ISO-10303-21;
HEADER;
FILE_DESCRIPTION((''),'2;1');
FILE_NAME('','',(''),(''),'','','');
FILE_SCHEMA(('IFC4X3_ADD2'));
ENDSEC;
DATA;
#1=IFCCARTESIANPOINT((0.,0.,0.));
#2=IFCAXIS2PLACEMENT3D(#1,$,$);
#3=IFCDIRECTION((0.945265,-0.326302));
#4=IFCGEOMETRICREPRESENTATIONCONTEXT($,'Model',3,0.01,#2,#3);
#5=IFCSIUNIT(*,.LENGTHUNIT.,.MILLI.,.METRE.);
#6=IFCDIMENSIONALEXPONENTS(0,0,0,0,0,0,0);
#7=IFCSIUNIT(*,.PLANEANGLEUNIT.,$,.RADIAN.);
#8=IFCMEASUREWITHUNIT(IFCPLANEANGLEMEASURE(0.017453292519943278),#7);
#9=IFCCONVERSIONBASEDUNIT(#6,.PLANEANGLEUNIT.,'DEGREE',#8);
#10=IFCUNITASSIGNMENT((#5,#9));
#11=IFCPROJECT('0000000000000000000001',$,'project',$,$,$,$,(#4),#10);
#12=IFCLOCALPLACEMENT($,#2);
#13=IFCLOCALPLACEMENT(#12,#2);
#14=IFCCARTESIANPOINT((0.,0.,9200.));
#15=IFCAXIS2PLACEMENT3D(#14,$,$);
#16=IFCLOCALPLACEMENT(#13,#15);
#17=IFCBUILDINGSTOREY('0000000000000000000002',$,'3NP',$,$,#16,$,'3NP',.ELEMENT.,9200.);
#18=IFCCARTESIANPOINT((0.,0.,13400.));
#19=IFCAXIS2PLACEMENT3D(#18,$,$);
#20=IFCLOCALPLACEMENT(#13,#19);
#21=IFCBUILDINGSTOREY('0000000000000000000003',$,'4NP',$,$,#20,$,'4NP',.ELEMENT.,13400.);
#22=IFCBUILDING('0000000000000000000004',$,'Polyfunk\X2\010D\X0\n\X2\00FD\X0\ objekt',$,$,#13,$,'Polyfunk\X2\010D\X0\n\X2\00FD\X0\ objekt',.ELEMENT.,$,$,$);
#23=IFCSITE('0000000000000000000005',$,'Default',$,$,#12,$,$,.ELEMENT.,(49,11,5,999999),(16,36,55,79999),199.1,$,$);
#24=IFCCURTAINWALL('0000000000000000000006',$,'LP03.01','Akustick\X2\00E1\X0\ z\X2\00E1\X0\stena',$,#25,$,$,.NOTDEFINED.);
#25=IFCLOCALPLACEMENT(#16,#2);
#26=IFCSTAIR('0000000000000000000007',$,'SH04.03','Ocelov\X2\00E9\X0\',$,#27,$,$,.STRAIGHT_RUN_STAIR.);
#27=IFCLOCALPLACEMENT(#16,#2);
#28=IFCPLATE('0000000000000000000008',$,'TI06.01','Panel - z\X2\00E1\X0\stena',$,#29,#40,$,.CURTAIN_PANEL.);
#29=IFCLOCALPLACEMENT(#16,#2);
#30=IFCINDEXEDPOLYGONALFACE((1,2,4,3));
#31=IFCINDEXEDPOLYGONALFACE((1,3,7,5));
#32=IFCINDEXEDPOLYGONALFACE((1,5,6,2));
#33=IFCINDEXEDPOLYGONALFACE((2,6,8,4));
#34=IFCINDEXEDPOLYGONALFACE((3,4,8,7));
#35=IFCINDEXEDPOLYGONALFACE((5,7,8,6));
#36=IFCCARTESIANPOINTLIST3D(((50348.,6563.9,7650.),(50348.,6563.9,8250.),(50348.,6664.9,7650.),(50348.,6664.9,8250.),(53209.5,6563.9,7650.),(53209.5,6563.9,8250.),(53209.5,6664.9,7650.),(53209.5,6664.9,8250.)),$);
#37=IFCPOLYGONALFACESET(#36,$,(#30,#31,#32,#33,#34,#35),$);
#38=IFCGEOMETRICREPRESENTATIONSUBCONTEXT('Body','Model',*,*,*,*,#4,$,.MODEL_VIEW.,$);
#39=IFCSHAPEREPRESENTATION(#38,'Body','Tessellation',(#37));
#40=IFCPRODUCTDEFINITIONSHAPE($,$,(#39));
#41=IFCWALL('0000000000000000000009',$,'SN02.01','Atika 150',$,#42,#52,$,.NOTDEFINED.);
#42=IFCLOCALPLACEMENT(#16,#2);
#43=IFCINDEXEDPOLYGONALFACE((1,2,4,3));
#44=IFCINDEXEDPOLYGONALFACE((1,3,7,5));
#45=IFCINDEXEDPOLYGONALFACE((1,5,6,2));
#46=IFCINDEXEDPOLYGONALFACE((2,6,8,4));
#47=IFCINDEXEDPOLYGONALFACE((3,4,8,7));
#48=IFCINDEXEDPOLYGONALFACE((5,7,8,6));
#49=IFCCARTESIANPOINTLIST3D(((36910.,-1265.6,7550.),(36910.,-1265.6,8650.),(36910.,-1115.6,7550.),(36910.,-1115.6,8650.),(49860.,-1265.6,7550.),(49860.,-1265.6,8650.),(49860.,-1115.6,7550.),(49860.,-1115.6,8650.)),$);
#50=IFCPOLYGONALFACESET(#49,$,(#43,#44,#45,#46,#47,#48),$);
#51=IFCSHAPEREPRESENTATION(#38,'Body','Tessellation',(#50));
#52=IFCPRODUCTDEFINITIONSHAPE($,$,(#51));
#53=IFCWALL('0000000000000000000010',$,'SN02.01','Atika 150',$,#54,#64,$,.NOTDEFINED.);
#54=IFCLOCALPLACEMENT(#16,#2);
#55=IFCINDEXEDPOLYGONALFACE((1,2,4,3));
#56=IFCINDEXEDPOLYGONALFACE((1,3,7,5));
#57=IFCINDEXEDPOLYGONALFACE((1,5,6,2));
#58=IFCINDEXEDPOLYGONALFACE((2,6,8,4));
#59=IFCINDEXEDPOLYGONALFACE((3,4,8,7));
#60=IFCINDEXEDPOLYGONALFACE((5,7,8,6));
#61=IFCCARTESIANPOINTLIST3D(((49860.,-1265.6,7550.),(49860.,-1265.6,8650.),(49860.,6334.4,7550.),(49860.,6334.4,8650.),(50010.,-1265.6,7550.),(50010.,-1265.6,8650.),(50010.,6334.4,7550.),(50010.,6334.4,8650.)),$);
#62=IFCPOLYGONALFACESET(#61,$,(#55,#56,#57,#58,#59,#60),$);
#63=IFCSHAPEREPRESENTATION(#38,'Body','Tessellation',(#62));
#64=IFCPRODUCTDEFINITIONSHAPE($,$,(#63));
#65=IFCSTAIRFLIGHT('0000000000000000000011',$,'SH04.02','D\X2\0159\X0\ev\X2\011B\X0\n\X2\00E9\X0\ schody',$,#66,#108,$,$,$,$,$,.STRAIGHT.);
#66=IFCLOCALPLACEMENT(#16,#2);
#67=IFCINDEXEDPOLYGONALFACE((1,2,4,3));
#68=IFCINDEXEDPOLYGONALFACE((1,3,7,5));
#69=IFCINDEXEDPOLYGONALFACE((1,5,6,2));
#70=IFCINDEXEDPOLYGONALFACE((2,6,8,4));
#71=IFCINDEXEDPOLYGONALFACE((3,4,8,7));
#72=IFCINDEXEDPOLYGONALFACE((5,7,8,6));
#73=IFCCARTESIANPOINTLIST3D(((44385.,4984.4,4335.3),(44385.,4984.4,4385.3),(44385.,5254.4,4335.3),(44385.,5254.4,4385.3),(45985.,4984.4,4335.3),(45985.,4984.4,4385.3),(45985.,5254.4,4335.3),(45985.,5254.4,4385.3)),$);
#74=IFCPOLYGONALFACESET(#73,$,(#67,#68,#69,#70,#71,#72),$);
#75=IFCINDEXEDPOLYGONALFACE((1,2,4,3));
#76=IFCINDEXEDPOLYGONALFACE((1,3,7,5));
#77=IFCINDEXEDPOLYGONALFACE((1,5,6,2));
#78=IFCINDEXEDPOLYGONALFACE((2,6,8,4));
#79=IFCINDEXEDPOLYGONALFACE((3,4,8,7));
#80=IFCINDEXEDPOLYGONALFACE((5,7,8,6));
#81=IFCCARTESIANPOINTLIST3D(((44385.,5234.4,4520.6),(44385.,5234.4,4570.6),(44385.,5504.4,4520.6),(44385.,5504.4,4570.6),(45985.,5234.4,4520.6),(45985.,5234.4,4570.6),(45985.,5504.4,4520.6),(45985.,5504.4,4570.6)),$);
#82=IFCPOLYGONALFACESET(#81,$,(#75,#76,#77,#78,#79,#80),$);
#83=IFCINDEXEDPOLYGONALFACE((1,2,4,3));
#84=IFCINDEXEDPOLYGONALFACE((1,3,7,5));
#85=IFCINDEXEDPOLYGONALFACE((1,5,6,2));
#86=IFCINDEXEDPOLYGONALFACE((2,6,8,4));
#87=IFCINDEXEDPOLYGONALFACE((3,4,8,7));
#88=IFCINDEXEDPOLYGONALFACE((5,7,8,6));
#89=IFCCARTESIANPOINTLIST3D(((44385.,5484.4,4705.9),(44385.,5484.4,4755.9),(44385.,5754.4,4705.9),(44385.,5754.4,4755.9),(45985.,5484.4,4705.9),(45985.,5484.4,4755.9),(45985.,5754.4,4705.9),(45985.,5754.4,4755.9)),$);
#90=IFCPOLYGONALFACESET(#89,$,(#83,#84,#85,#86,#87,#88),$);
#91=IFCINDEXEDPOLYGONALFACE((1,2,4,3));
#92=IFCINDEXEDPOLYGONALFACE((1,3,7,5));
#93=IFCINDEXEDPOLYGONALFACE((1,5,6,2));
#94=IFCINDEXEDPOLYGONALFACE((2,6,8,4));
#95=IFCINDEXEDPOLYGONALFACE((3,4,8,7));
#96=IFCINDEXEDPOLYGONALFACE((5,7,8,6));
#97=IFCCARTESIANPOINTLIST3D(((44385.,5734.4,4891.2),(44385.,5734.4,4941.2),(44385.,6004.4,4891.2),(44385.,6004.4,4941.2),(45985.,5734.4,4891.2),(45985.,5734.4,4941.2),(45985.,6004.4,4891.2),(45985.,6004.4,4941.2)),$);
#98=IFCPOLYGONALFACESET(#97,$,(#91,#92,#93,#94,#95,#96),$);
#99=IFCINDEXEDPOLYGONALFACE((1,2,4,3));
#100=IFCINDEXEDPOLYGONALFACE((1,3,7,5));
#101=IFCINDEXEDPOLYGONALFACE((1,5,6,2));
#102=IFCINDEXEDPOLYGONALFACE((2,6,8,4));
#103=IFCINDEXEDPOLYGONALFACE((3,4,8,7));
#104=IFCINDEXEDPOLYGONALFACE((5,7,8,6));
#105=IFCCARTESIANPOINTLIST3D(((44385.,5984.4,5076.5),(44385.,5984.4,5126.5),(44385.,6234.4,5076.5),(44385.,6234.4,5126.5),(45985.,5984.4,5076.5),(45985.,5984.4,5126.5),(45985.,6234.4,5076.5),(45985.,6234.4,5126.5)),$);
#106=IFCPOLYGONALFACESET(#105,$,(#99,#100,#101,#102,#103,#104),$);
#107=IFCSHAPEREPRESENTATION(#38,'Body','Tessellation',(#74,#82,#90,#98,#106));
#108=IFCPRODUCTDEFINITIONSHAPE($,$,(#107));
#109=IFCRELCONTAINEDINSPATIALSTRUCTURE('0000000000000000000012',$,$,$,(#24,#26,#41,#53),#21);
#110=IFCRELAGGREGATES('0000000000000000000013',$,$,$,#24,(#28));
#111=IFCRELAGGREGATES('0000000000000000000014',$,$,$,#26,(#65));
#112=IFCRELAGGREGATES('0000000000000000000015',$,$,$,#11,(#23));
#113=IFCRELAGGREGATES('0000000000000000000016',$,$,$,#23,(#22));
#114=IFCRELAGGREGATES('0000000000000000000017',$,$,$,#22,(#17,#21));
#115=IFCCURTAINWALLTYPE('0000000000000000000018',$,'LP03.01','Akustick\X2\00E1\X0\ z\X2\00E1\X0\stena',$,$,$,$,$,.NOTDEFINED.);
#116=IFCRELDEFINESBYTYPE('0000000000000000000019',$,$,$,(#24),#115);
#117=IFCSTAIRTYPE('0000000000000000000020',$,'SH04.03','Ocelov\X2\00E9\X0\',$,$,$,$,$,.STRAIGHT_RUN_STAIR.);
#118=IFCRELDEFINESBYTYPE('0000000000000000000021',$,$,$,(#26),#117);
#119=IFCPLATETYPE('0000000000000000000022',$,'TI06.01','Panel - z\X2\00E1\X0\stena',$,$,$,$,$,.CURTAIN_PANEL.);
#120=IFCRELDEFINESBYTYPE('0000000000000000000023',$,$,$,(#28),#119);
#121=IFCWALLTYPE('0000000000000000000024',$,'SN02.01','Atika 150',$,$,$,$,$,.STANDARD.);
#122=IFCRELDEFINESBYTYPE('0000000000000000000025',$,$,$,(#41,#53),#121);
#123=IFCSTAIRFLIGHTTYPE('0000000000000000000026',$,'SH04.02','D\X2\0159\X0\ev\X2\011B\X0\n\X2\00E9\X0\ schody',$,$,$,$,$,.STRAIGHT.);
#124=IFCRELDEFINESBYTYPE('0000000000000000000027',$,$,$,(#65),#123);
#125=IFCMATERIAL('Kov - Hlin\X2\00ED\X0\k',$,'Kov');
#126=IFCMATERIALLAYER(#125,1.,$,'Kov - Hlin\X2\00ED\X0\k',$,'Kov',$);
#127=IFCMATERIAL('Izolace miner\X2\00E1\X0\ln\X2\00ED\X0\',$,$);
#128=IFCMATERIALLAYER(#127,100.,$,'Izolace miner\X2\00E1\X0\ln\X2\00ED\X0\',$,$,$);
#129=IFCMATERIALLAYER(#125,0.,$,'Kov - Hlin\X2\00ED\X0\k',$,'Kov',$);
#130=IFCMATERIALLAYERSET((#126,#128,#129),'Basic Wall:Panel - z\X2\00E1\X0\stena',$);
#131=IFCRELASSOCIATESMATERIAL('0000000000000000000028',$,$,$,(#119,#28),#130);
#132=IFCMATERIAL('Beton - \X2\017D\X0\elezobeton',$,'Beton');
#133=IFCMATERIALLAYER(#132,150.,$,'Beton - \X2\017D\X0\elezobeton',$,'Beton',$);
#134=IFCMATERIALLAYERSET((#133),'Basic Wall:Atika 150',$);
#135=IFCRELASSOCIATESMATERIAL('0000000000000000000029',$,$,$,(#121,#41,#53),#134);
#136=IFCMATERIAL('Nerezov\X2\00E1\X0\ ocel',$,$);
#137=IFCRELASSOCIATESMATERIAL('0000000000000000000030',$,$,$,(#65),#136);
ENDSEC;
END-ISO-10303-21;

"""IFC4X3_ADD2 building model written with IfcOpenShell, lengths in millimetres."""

from ifc_helpers import new_model, entity, si_unit, converted_unit, direction, frame, frame_2d, origin, origin_2d_with_axis, place, context, subcontext, project, spatial, rectangle, extrude, material, layer, layer_set, layer_usage, type_object, element, aggregate, save


model = new_model("IFC4X3_ADD2")

# Units and contexts
model_context = context("Model", 3, precision=0.01, world=origin(), true_north=direction((0.945265, -0.326302)))
body_context = subcontext(model_context, "Body", "Model", "MODEL_VIEW")
ifc_project = project(units=[si_unit("LENGTHUNIT", "METRE", prefix="MILLI"), converted_unit("PLANEANGLEUNIT", "DEGREE", entity("IfcPlaneAngleMeasure", 0.017453292519943278), si_unit("PLANEANGLEUNIT", "RADIAN"), dimensions=[0, 0, 0, 0, 0, 0, 0])], contexts=[model_context])

# Site, building, storey
site_placement = place(None, origin())
site = spatial("IfcSite", under=ifc_project, at=site_placement, Name="Default", CompositionType="ELEMENT", RefLatitude=(49, 11, 5, 999999), RefLongitude=(16, 36, 55, 79999), RefElevation=199.1)
building_placement = place(site_placement, origin())
building = spatial("IfcBuilding", under=site, at=building_placement, Name="Polyfunkčný objekt", LongName="Polyfunkčný objekt", CompositionType="ELEMENT")
storey_1_placement = place(building_placement, frame((0.0, 0.0, 9200.0)))
storey_1 = spatial("IfcBuildingStorey", under=building, at=storey_1_placement, Name="3NP", LongName="3NP", CompositionType="ELEMENT", Elevation=9200.0)

# Shared definitions
storey_2_placement = place(building_placement, frame((0.0, 0.0, 13400.0)))
storey_2 = spatial("IfcBuildingStorey", under=building, at=storey_2_placement, Name="4NP", LongName="4NP", CompositionType="ELEMENT", Elevation=13400.0)

# Curtain wall
curtain_wall_type_1 = type_object("IfcCurtainWallType", Name="LP03.01", Description="Akustická zástena", PredefinedType="NOTDEFINED")
curtain_wall_1_placement = place(storey_2_placement, frame((0.0, 0.0, -13400.0)))
curtain_wall_1 = element("IfcCurtainWall", 1, at=curtain_wall_1_placement, inside=storey_2, type_object=curtain_wall_type_1, Name="LP03.01", Description="Akustická zástena", PredefinedType="NOTDEFINED")
ifc_material_1 = material(Name="Nerezová ocel")

# Stair
stair_type = type_object("IfcStairType", Name="SH04.03", Description="Ocelové", PredefinedType="STRAIGHT_RUN_STAIR")
stair_placement = place(storey_2_placement, origin())
stair = element("IfcStair", 2, at=stair_placement, inside=storey_2, type_object=stair_type, Name="SH04.03", Description="Ocelové", PredefinedType="STRAIGHT_RUN_STAIR")

# Plate
ifc_material_2 = material(Name="Kov - Hliník", Category="Kov")
ifc_layer_1 = layer(ifc_material_2, 1.0, Name="Kov - Hliník", Category="Kov")
ifc_material_3 = material(Name="Izolace minerální")
ifc_layer_2 = layer(ifc_material_3, 100.0, Name="Izolace minerální")
ifc_layer_3 = layer(ifc_material_2, 0.0, Name="Kov - Hliník", Category="Kov")
ifc_layer_set_1 = layer_set([ifc_layer_1, ifc_layer_2, ifc_layer_3], Name="Basic Wall:Panel - zástena")
plate_type = type_object("IfcPlateType", Name="TI06.01", Description="Panel - zástena", PredefinedType="CURTAIN_PANEL", material=ifc_layer_set_1)
ifc_layer_usage_1 = layer_usage(ifc_layer_set_1, "AXIS2", "POSITIVE", -50.5)
plate_1_placement = place(storey_2_placement, frame((50348.0, 6614.4, 3450.0)))
plate_1 = element("IfcPlate", 3, at=plate_1_placement, type_object=plate_type, material=ifc_layer_usage_1, Name="TI06.01", Description="Panel - zástena", PredefinedType="CURTAIN_PANEL", context=body_context, shape_type="SweptSolid", body=[
    extrude(rectangle(XDim=101.0, YDim=2861.5, at=frame_2d((0.0, 0.0), x_axis=(1.0, 0.0))), frame((1430.7, 0.0, 0.0), z_axis=(0.0, 0.0, 1.0), x_axis=(0.0, 1.0, 0.0)), (0.0, 0.0, 1.0), 600.0),
])
aggregate(curtain_wall_1, [plate_1])

# Walls
ifc_material_4 = material(Name="Beton - Železobeton", Category="Beton")
ifc_layer_4 = layer(ifc_material_4, 150.0, Name="Beton - Železobeton", Category="Beton")
ifc_layer_set_2 = layer_set([ifc_layer_4], Name="Basic Wall:Atika 150")
wall_type = type_object("IfcWallType", Name="SN02.01", Description="Atika 150", PredefinedType="STANDARD", material=ifc_layer_set_2)
wall_1_placement = place(storey_2_placement, frame((49860.0, -1190.6, 3350.0), z_axis=(0.0, 0.0, 1.0), x_axis=(-1.0, 0.0, 0.0)))
element("IfcWall", 4, at=wall_1_placement, inside=storey_2, type_object=wall_type, material=ifc_layer_set_2, Name="SN02.01", Description="Atika 150", PredefinedType="NOTDEFINED", context=body_context, shape_type="SweptSolid", body=[
    extrude(rectangle(XDim=12950.0, YDim=150.0, at=frame_2d((6475.0, 0.0), x_axis=(-1.0, 0.0))), origin(), (0.0, 0.0, 1.0), 1100.0),
])
wall_2_placement = place(storey_2_placement, frame((49935.0, 6334.4, 3350.0), z_axis=(0.0, 0.0, 1.0), x_axis=(0.0, -1.0, 0.0)))
element("IfcWall", 5, at=wall_2_placement, inside=storey_2, type_object=wall_type, material=ifc_layer_set_2, Name="SN02.01", Description="Atika 150", PredefinedType="NOTDEFINED", context=body_context, shape_type="SweptSolid", body=[
    extrude(rectangle(XDim=7600.0, YDim=150.0, at=frame_2d((3800.0, 0.0), x_axis=(-1.0, 0.0))), origin(), (0.0, 0.0, 1.0), 1100.0),
])

# Stair flight
stair_flight_type = type_object("IfcStairFlightType", Name="SH04.02", Description="Dřevěné schody", PredefinedType="STRAIGHT")
stair_flight_placement = place(stair_placement, frame((44385.0, 4984.4, 0.0)))
stair_flight = element("IfcStairFlight", 6, at=stair_flight_placement, type_object=stair_flight_type, material=ifc_material_1, Name="SH04.02", Description="Dřevěné schody", PredefinedType="STRAIGHT", context=body_context, shape_type="SweptSolid", body=[
    extrude(rectangle(XDim=270.0, YDim=1600.0, at=origin_2d_with_axis()), frame((800.0, 135.0, 135.3), z_axis=(0.0, 0.0, 1.0), x_axis=(0.0, -1.0, 0.0)), (0.0, 0.0, 1.0), 50.0),
    extrude(rectangle(XDim=270.0, YDim=1600.0, at=origin_2d_with_axis()), frame((800.0, 385.0, 320.6), z_axis=(0.0, 0.0, 1.0), x_axis=(0.0, -1.0, 0.0)), (0.0, 0.0, 1.0), 50.0),
    extrude(rectangle(XDim=270.0, YDim=1600.0, at=origin_2d_with_axis()), frame((800.0, 635.0, 505.9), z_axis=(0.0, 0.0, 1.0), x_axis=(0.0, -1.0, 0.0)), (0.0, 0.0, 1.0), 50.0),
    extrude(rectangle(XDim=270.0, YDim=1600.0, at=origin_2d_with_axis()), frame((800.0, 885.0, 691.2), z_axis=(0.0, 0.0, 1.0), x_axis=(0.0, -1.0, 0.0)), (0.0, 0.0, 1.0), 50.0),
    extrude(rectangle(XDim=250.0, YDim=1600.0, at=origin_2d_with_axis()), frame((800.0, 1125.0, 876.5), z_axis=(0.0, 0.0, 1.0), x_axis=(0.0, -1.0, 0.0)), (0.0, 0.0, 1.0), 50.0),
])
aggregate(stair, [stair_flight])

save(model, "model.ifc")
